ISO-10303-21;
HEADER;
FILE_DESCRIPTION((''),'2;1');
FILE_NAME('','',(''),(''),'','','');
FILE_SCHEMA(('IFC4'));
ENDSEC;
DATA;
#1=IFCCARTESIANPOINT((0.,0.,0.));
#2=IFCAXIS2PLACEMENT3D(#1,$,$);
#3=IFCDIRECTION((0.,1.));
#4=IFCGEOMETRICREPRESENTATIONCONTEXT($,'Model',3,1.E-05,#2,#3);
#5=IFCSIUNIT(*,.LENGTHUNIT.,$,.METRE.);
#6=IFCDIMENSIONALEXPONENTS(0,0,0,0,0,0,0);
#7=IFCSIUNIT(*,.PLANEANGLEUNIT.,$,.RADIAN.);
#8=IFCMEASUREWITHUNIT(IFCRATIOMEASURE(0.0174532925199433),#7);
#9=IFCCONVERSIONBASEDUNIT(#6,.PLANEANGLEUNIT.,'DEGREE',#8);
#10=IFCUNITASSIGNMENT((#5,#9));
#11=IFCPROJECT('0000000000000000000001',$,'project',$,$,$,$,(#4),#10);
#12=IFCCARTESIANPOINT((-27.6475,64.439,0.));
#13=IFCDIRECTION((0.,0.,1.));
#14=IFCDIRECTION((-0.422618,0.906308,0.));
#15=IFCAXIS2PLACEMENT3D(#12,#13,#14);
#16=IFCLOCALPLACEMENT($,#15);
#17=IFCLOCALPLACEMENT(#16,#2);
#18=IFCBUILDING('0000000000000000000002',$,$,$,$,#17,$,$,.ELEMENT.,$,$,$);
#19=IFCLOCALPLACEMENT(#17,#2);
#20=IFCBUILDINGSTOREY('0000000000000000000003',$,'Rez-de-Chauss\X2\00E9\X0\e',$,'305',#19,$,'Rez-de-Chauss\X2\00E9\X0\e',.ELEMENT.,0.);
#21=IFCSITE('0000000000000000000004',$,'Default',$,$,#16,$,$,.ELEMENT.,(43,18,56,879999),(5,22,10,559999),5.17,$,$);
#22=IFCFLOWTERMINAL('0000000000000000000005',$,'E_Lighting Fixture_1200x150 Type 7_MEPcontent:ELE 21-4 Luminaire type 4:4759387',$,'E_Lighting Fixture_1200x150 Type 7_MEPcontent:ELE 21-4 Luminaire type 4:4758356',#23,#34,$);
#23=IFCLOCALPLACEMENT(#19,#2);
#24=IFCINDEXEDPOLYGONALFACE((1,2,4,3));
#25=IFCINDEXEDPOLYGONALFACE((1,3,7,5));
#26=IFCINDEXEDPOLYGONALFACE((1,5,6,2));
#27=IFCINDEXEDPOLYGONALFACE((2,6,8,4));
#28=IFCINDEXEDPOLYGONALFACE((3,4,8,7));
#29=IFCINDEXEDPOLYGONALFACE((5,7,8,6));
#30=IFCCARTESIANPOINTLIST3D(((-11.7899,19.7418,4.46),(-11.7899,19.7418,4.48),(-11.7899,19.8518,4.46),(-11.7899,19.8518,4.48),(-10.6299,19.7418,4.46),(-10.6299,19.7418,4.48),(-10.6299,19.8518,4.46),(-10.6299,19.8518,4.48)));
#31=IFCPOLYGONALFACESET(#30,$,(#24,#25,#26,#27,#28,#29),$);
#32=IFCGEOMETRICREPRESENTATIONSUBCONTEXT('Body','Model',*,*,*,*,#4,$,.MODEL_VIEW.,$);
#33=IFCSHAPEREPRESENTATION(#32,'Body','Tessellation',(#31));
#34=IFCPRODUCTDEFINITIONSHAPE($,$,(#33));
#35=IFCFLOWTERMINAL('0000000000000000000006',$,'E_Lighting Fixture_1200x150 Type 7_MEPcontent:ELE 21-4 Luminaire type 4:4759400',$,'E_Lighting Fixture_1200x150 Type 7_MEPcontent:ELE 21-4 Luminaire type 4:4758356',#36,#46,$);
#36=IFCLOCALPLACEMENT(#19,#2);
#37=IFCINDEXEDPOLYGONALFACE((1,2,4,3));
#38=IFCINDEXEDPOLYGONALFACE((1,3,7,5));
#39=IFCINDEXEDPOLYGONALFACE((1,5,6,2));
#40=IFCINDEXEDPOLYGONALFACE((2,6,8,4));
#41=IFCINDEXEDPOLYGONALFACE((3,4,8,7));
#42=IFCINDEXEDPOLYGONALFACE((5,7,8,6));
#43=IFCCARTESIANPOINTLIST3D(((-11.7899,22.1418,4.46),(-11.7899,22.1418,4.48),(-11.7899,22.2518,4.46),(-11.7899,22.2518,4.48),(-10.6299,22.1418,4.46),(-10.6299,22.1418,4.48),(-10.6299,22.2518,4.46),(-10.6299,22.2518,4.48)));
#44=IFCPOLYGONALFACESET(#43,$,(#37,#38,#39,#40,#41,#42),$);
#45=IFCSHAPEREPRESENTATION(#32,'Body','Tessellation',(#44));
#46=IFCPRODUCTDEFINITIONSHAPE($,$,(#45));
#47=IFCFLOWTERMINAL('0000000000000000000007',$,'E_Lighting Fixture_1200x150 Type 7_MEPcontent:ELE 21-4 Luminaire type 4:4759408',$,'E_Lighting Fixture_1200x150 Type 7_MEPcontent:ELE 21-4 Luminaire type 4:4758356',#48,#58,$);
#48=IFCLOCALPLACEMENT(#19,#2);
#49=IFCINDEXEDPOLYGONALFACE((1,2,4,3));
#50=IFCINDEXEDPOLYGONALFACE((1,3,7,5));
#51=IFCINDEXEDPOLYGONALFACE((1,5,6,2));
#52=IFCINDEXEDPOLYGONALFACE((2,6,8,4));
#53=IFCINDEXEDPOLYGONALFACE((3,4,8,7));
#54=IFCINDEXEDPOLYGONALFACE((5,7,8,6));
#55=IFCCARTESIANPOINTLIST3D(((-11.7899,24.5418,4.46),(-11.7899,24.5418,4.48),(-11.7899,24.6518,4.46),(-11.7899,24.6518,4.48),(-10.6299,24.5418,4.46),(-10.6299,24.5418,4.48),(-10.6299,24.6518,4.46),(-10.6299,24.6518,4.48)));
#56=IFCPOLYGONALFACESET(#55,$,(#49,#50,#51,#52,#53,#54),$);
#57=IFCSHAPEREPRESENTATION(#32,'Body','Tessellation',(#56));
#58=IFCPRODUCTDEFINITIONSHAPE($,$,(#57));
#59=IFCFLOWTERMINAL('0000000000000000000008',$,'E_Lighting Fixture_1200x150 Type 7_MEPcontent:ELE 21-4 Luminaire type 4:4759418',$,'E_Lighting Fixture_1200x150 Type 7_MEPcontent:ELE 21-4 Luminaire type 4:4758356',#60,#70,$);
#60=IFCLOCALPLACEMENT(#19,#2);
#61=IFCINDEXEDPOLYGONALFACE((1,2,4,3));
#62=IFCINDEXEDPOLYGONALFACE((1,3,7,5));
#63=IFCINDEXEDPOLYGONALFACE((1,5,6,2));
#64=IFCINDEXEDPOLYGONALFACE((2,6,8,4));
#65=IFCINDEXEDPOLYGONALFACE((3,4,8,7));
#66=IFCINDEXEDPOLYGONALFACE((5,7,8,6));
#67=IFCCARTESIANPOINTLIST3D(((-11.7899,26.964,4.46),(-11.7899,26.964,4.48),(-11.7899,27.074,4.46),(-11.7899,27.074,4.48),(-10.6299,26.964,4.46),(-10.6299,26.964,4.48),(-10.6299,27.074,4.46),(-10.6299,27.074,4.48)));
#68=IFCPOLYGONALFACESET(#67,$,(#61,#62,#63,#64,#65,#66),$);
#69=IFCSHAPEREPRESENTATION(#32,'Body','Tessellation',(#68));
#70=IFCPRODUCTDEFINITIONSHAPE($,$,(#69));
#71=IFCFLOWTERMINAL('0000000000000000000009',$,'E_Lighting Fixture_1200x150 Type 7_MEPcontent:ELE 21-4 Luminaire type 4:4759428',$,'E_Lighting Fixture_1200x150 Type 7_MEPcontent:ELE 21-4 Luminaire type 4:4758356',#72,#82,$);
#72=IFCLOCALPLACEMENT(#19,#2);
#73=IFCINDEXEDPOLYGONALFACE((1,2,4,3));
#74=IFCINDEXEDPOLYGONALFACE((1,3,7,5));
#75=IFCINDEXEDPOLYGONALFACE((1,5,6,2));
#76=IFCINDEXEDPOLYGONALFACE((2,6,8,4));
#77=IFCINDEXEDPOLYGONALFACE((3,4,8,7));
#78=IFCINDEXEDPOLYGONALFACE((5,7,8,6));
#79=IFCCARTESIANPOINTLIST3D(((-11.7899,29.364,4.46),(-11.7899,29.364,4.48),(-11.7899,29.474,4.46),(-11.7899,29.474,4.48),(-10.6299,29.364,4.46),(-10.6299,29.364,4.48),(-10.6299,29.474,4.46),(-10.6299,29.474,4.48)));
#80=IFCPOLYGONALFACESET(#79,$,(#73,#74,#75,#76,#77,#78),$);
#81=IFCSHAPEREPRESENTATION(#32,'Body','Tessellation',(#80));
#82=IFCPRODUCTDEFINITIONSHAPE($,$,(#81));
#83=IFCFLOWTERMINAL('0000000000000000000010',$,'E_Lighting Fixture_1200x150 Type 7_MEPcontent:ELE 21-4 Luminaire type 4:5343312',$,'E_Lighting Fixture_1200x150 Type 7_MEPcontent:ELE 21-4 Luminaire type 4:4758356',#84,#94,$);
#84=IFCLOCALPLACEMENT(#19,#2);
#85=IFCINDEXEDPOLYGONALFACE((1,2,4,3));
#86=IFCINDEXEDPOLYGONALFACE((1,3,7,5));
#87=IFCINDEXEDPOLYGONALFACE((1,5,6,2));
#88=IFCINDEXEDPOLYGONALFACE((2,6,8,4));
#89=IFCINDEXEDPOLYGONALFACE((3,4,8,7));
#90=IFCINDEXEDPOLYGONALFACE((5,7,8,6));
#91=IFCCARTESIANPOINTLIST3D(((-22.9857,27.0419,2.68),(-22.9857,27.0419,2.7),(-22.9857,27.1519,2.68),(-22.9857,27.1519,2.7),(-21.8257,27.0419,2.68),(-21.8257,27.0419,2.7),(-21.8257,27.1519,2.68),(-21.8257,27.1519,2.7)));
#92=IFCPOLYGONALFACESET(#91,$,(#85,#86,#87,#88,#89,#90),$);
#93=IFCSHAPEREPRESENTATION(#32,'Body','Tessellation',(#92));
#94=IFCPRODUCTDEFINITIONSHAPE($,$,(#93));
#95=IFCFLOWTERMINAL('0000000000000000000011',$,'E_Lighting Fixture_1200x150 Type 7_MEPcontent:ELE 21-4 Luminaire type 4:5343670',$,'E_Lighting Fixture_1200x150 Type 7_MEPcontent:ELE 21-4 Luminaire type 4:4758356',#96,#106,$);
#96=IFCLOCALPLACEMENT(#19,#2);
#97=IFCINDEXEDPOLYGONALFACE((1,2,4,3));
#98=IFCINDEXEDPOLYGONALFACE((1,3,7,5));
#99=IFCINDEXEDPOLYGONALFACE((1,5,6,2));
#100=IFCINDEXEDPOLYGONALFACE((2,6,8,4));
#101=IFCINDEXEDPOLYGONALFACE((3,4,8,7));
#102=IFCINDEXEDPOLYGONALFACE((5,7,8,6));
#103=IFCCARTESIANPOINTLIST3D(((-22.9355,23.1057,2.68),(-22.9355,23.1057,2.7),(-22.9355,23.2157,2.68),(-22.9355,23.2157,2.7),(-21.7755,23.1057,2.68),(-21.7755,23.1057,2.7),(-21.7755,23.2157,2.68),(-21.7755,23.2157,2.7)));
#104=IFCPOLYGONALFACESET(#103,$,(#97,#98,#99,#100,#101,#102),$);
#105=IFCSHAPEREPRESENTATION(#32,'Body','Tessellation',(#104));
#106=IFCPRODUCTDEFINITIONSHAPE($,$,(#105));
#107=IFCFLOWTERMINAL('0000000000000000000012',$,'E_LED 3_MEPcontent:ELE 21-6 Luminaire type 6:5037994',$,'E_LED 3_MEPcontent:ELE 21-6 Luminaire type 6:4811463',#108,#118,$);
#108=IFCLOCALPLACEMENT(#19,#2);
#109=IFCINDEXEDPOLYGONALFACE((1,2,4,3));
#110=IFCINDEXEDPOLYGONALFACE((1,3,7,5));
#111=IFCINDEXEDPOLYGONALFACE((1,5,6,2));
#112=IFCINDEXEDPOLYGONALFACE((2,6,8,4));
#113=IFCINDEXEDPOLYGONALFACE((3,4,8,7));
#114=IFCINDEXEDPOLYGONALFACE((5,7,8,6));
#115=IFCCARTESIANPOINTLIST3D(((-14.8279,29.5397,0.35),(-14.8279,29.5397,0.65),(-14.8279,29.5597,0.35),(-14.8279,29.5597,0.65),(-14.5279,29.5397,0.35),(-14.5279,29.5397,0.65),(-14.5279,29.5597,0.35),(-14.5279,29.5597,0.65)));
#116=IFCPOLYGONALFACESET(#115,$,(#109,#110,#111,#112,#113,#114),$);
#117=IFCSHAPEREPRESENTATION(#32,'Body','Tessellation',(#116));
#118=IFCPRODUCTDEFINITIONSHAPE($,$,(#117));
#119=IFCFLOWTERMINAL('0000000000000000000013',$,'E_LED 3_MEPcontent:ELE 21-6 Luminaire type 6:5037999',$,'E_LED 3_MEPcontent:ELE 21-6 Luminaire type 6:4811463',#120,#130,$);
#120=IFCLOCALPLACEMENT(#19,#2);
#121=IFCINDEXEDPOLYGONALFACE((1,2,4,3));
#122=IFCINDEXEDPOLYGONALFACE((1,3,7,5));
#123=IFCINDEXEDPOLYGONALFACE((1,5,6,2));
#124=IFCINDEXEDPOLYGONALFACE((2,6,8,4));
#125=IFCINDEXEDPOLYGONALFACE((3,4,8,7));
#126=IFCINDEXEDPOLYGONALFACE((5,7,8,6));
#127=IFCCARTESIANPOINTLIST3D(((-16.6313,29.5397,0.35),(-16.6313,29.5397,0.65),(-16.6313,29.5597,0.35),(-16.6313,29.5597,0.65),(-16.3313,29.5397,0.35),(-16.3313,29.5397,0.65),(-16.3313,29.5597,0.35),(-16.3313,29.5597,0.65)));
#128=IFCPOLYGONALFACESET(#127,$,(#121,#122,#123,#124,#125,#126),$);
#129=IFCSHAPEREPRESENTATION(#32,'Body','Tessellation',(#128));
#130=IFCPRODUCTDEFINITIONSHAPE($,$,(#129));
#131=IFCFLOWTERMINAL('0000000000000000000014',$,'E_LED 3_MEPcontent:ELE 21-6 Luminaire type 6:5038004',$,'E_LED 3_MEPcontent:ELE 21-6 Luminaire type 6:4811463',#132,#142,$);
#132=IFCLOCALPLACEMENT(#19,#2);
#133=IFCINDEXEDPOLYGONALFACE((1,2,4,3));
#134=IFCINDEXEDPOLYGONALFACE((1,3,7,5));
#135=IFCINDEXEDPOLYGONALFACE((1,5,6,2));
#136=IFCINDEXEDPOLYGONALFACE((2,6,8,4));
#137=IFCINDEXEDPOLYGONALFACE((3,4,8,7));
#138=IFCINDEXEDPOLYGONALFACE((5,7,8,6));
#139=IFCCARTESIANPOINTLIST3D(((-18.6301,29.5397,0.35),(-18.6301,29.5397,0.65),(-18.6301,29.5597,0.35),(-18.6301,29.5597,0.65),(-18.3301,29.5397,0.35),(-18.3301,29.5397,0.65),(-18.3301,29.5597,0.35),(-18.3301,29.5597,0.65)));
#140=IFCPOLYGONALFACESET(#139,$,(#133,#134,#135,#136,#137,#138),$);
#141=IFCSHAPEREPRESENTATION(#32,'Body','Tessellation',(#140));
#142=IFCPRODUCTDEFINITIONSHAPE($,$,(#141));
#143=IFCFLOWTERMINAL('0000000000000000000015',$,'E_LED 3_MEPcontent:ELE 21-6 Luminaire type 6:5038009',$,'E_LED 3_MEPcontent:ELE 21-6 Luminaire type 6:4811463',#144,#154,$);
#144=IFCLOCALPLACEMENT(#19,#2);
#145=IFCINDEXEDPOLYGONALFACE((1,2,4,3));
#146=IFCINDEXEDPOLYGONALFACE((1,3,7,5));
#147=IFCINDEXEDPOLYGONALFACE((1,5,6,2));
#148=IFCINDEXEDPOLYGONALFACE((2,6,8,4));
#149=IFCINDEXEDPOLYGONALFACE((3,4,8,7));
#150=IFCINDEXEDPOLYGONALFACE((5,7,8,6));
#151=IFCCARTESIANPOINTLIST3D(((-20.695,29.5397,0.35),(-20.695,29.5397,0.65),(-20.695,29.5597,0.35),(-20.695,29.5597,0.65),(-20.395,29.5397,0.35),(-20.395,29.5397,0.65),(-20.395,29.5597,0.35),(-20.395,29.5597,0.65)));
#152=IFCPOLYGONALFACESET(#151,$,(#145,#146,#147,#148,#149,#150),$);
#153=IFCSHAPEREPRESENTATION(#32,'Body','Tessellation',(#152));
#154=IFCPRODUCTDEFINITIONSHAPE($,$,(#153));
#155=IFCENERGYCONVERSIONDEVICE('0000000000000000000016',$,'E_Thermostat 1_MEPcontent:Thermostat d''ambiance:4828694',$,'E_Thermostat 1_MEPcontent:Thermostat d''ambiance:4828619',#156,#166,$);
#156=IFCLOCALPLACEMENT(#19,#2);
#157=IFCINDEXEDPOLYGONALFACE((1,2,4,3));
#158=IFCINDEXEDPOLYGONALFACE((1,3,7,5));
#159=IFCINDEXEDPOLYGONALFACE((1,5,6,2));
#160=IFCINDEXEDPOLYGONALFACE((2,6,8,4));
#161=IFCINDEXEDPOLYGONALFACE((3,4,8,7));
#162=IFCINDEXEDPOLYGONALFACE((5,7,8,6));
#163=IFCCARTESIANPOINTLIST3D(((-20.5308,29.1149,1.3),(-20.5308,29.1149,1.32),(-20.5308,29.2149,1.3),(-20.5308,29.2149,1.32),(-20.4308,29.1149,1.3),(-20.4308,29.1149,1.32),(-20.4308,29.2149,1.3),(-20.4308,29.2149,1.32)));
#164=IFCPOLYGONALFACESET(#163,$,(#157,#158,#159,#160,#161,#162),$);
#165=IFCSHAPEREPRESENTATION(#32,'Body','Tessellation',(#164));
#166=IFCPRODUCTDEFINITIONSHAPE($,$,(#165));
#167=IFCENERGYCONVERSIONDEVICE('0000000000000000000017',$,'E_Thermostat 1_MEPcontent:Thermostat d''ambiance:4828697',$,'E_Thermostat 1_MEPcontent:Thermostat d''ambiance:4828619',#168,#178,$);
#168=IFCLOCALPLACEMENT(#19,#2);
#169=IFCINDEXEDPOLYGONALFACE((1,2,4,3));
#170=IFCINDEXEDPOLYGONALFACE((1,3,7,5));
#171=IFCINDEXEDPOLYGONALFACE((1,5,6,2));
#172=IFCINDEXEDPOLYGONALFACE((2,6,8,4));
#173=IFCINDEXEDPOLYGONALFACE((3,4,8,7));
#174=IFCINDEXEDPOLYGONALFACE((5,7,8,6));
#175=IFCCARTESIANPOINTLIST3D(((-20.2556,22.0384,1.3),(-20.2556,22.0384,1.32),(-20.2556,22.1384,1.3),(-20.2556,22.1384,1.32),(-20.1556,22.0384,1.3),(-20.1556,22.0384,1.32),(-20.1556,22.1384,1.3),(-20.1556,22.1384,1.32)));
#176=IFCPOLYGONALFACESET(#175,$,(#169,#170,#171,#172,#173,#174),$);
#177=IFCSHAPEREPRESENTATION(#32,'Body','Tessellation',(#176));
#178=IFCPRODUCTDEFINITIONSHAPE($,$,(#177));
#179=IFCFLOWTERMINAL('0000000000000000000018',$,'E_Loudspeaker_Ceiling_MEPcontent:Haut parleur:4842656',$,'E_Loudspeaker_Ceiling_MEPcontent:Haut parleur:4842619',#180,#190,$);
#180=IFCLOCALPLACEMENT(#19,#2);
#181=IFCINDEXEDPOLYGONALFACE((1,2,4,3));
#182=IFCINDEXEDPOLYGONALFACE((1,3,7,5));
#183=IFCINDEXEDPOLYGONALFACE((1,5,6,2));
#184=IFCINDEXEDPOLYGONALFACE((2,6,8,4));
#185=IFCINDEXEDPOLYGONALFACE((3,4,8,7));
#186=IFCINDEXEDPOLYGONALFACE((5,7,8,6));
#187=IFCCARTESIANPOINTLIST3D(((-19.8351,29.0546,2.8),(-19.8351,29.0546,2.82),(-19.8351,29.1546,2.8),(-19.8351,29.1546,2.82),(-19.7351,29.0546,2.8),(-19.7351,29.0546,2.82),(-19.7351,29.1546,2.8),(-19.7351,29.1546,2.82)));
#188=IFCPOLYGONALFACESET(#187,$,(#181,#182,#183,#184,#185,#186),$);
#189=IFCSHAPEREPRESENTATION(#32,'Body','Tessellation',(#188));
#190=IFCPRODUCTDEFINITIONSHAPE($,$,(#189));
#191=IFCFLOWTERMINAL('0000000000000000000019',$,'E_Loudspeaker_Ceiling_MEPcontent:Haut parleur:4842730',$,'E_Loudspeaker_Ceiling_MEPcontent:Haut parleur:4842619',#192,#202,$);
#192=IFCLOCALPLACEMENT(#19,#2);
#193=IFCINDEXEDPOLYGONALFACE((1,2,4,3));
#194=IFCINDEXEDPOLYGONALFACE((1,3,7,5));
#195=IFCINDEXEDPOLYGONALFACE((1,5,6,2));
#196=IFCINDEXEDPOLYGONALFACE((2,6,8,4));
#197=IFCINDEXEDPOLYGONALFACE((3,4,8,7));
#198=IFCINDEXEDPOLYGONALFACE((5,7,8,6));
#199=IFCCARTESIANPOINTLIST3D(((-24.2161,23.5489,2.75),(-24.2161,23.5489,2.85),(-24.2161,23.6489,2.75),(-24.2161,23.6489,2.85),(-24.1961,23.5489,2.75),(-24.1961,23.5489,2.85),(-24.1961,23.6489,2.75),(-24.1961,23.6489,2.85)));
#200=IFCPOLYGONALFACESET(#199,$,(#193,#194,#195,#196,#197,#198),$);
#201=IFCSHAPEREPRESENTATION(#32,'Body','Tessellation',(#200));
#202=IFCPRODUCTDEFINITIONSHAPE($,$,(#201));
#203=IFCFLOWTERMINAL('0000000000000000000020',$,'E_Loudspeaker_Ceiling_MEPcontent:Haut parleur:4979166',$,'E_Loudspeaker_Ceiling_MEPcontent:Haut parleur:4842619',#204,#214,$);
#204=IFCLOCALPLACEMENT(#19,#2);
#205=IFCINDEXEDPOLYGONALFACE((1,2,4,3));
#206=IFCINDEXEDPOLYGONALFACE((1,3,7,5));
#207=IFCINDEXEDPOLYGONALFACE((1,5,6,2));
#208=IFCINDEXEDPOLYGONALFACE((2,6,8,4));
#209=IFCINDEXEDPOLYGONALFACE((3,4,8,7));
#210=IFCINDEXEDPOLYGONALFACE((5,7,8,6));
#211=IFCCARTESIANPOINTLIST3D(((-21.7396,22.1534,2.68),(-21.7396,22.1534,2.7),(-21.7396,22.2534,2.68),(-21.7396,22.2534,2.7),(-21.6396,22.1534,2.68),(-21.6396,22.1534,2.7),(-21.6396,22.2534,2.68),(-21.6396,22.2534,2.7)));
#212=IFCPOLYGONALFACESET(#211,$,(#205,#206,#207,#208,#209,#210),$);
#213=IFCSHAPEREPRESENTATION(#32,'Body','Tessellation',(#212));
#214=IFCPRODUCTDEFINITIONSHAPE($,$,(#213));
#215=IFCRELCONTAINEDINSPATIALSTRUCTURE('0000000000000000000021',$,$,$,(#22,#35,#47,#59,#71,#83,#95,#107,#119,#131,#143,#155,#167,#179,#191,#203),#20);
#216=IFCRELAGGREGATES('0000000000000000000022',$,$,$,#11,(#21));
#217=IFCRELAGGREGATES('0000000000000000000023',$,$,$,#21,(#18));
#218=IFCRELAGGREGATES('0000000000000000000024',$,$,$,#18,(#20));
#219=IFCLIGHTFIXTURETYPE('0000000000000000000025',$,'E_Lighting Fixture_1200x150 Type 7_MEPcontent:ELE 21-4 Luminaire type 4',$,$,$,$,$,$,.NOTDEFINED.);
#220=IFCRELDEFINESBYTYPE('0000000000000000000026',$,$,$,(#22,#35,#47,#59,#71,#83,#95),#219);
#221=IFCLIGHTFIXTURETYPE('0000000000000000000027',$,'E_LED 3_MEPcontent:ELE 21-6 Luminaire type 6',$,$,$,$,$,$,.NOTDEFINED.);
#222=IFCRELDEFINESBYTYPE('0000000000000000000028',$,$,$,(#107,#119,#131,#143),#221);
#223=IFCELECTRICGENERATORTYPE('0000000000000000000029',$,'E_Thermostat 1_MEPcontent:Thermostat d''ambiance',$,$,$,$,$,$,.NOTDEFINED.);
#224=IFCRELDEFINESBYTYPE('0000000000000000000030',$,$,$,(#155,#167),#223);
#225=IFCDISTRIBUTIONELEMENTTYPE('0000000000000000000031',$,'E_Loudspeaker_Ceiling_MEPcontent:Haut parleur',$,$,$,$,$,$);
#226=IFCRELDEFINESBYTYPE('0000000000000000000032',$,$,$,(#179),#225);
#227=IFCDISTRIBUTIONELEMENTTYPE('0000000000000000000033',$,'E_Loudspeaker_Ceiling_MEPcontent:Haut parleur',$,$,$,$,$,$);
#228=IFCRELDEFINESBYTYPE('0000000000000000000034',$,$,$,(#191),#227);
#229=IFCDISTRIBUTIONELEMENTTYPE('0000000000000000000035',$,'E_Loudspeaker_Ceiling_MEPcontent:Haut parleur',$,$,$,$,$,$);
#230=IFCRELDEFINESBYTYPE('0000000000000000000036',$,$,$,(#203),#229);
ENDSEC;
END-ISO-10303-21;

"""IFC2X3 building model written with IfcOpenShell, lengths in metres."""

from ifc_helpers import new_model, entity, si_unit, converted_unit, direction, frame, frame_2d, origin, origin_2d_with_axis, place, context, subcontext, project, spatial, rectangle, extrude, source, transform, mapped, type_object, type_shapes, element, save


model = new_model("IFC2X3")

# Units and contexts
model_context = context("Model", 3, precision=1e-05, world=origin(), true_north=direction((0.0, 1.0)))
body_context = subcontext(model_context, "Body", "Model", "MODEL_VIEW")
ifc_project = project(units=[si_unit("LENGTHUNIT", "METRE"), converted_unit("PLANEANGLEUNIT", "DEGREE", entity("IfcRatioMeasure", 0.0174532925199433), si_unit("PLANEANGLEUNIT", "RADIAN"), dimensions=[0, 0, 0, 0, 0, 0, 0])], contexts=[model_context])

# Site, building, storey
site_placement = place(None, frame((-27.6475, 64.439, 0.0), z_axis=(0.0, 0.0, 1.0), x_axis=(-0.422618, 0.906308, 0.0)))
site = spatial("IfcSite", under=ifc_project, at=site_placement, Name="Default", CompositionType="ELEMENT", RefLatitude=(43, 18, 56, 879999), RefLongitude=(5, 22, 10, 559999), RefElevation=5.17)
building_placement = place(site_placement, origin())
building = spatial("IfcBuilding", under=site, at=building_placement, CompositionType="ELEMENT")
storey_placement = place(building_placement, origin())
storey = spatial("IfcBuildingStorey", under=building, at=storey_placement, Name="Rez-de-Chaussée", ObjectType="305", LongName="Rez-de-Chaussée", CompositionType="ELEMENT", Elevation=0.0)

# Flow terminals
light_fixture_type_1 = type_object("IfcLightFixtureType", Name="E_Lighting Fixture_1200x150 Type 7_MEPcontent:ELE 21-4 Luminaire type 4", PredefinedType="NOTDEFINED")
shared_shape_1 = source(origin(), body_context, "Body", "SweptSolid", [
    extrude(rectangle(XDim=0.11, YDim=1.16, at=origin_2d_with_axis()), frame((0.0, 0.0, 0.0), z_axis=(0.0, 0.0, 1.0), x_axis=(0.0, -1.0, 0.0)), (0.0, 0.0, 1.0), 0.02),
])
type_shapes(light_fixture_type_1, [shared_shape_1])
for number, where, name in (
    (1, (-11.2099, 19.7968, 4.46), "E_Lighting Fixture_1200x150 Type 7_MEPcontent:ELE 21-4 Luminaire type 4:4759387"),
    (2, (-11.2099, 22.1968, 4.46), "E_Lighting Fixture_1200x150 Type 7_MEPcontent:ELE 21-4 Luminaire type 4:4759400"),
    (3, (-11.2099, 24.5968, 4.46), "E_Lighting Fixture_1200x150 Type 7_MEPcontent:ELE 21-4 Luminaire type 4:4759408"),
    (4, (-11.2099, 27.019, 4.46), "E_Lighting Fixture_1200x150 Type 7_MEPcontent:ELE 21-4 Luminaire type 4:4759418"),
    (5, (-11.2099, 29.419, 4.46), "E_Lighting Fixture_1200x150 Type 7_MEPcontent:ELE 21-4 Luminaire type 4:4759428"),
    (6, (-22.4057, 27.0969, 2.68), "E_Lighting Fixture_1200x150 Type 7_MEPcontent:ELE 21-4 Luminaire type 4:5343312"),
    (7, (-22.3555, 23.1607, 2.68), "E_Lighting Fixture_1200x150 Type 7_MEPcontent:ELE 21-4 Luminaire type 4:5343670"),
):
    element("IfcFlowTerminal", number, at=place(storey_placement, frame(where)), inside=storey, type_object=light_fixture_type_1, Name=name, ObjectType="E_Lighting Fixture_1200x150 Type 7_MEPcontent:ELE 21-4 Luminaire type 4:4758356", context=body_context, shape_type="MappedRepresentation", body=[
        mapped(shared_shape_1, transform((0.0, 0.0, 0.0), scale=1.0)),
    ])
light_fixture_type_2 = type_object("IfcLightFixtureType", Name="E_LED 3_MEPcontent:ELE 21-6 Luminaire type 6", PredefinedType="NOTDEFINED")
shared_shape_2 = source(origin(), body_context, "Body", "SweptSolid", [
    extrude(rectangle(XDim=0.02, YDim=0.3, at=origin_2d_with_axis()), frame((-0.01, 0.0, -0.15)), (0.0, 0.0, 1.0), 0.3),
])
type_shapes(light_fixture_type_2, [shared_shape_2])
for number, where, z_axis, x_axis, name in (
    (8, (-14.6779, 29.5397, 0.5), (0.0, 0.0, 1.0), (0.0, -1.0, 0.0), "E_LED 3_MEPcontent:ELE 21-6 Luminaire type 6:5037994"),
    (9, (-16.4813, 29.5397, 0.5), (0.0, 0.0, 1.0), (0.0, -1.0, 0.0), "E_LED 3_MEPcontent:ELE 21-6 Luminaire type 6:5037999"),
    (10, (-18.4801, 29.5397, 0.5), (0.0, 0.0, 1.0), (0.0, -1.0, 0.0), "E_LED 3_MEPcontent:ELE 21-6 Luminaire type 6:5038004"),
    (11, (-20.545, 29.5397, 0.5), (0.0, 0.0, 1.0), (0.0, -1.0, 0.0), "E_LED 3_MEPcontent:ELE 21-6 Luminaire type 6:5038009"),
):
    element("IfcFlowTerminal", number, at=place(storey_placement, frame(where, z_axis=z_axis, x_axis=x_axis)), inside=storey, type_object=light_fixture_type_2, Name=name, ObjectType="E_LED 3_MEPcontent:ELE 21-6 Luminaire type 6:4811463", context=body_context, shape_type="MappedRepresentation", body=[
        mapped(shared_shape_2, transform((0.0, 0.0, 0.0), scale=1.0)),
    ])

# Energy conversion devices
electric_generator_type = type_object("IfcElectricGeneratorType", Name="E_Thermostat 1_MEPcontent:Thermostat d'ambiance", PredefinedType="NOTDEFINED")
shared_shape_3 = source(origin(), body_context, "Body", "SweptSolid", [
    extrude(rectangle(XDim=0.1, YDim=0.1, at=origin_2d_with_axis()), frame((0.0, 0.0, 0.0), z_axis=(0.0, 0.0, 1.0), x_axis=(0.0, -1.0, 0.0)), (0.0, 0.0, 1.0), 0.02),
])
type_shapes(electric_generator_type, [shared_shape_3])
for number, where, z_axis, x_axis, name in (
    (12, (-20.4808, 29.1649, 1.3), (0.0, 0.0, 1.0), (0.0, -1.0, 0.0), "E_Thermostat 1_MEPcontent:Thermostat d'ambiance:4828694"),
    (13, (-20.2056, 22.0884, 1.3), (0.0, 0.0, 1.0), (-1.0, 0.0, 0.0), "E_Thermostat 1_MEPcontent:Thermostat d'ambiance:4828697"),
):
    element("IfcEnergyConversionDevice", number, at=place(storey_placement, frame(where, z_axis=z_axis, x_axis=x_axis)), inside=storey, type_object=electric_generator_type, Name=name, ObjectType="E_Thermostat 1_MEPcontent:Thermostat d'ambiance:4828619", context=body_context, shape_type="MappedRepresentation", body=[
        mapped(shared_shape_3, transform((0.0, 0.0, 0.0), scale=1.0)),
    ])

# Flow terminals
distribution_element_type_1 = type_object("IfcDistributionElementType", Name="E_Loudspeaker_Ceiling_MEPcontent:Haut parleur")
shared_shape_4 = source(origin(), body_context, "Body", "SweptSolid", [
    extrude(rectangle(XDim=0.1, YDim=0.1, at=origin_2d_with_axis()), frame((0.0, 0.0, 0.0), z_axis=(0.0, 0.0, 1.0), x_axis=(0.0, -1.0, 0.0)), (0.0, 0.0, 1.0), 0.02),
])
type_shapes(distribution_element_type_1, [shared_shape_4])
flow_terminal_1_placement = place(storey_placement, frame((-19.7851, 29.1046, 2.8), z_axis=(0.0, 0.0, 1.0), x_axis=(-1.0, 0.0, 0.0)))
element("IfcFlowTerminal", 14, at=flow_terminal_1_placement, inside=storey, type_object=distribution_element_type_1, Name="E_Loudspeaker_Ceiling_MEPcontent:Haut parleur:4842656", ObjectType="E_Loudspeaker_Ceiling_MEPcontent:Haut parleur:4842619", context=body_context, shape_type="MappedRepresentation", body=[
    mapped(shared_shape_4, transform((0.0, 0.0, 0.0), scale=1.0)),
])
distribution_element_type_2 = type_object("IfcDistributionElementType", Name="E_Loudspeaker_Ceiling_MEPcontent:Haut parleur")
shared_shape_5 = source(origin(), body_context, "Body", "SweptSolid", [
    extrude(rectangle(XDim=0.02, YDim=0.1, at=frame_2d((0.0, 0.0), x_axis=(1.0, 0.0))), frame((0.0, 0.01, -0.05), z_axis=(0.0, 0.0, 1.0), x_axis=(0.0, -1.0, 0.0)), (0.0, 0.0, 1.0), 0.1),
])
type_shapes(distribution_element_type_2, [shared_shape_5])
flow_terminal_2_placement = place(storey_placement, frame((-24.1961, 23.5989, 2.8), z_axis=(0.0, 0.0, 1.0), x_axis=(0.0, 1.0, 0.0)))
element("IfcFlowTerminal", 15, at=flow_terminal_2_placement, inside=storey, type_object=distribution_element_type_2, Name="E_Loudspeaker_Ceiling_MEPcontent:Haut parleur:4842730", ObjectType="E_Loudspeaker_Ceiling_MEPcontent:Haut parleur:4842619", context=body_context, shape_type="MappedRepresentation", body=[
    mapped(shared_shape_5, transform((0.0, 0.0, 0.0), scale=1.0)),
])
distribution_element_type_3 = type_object("IfcDistributionElementType", Name="E_Loudspeaker_Ceiling_MEPcontent:Haut parleur")
shared_shape_6 = source(origin(), body_context, "Body", "SweptSolid", [
    extrude(rectangle(XDim=0.1, YDim=0.1, at=origin_2d_with_axis()), frame((0.0, 0.0, -0.02)), (0.0, 0.0, 1.0), 0.02),
])
type_shapes(distribution_element_type_3, [shared_shape_6])
flow_terminal_3_placement = place(storey_placement, frame((-21.6896, 22.2034, 2.7), z_axis=(0.0, 0.0, 1.0), x_axis=(0.0, 1.0, 0.0)))
element("IfcFlowTerminal", 16, at=flow_terminal_3_placement, inside=storey, type_object=distribution_element_type_3, Name="E_Loudspeaker_Ceiling_MEPcontent:Haut parleur:4979166", ObjectType="E_Loudspeaker_Ceiling_MEPcontent:Haut parleur:4842619", context=body_context, shape_type="MappedRepresentation", body=[
    mapped(shared_shape_6, transform((0.0, 0.0, 0.0), scale=1.0)),
])

save(model, "model.ifc")
